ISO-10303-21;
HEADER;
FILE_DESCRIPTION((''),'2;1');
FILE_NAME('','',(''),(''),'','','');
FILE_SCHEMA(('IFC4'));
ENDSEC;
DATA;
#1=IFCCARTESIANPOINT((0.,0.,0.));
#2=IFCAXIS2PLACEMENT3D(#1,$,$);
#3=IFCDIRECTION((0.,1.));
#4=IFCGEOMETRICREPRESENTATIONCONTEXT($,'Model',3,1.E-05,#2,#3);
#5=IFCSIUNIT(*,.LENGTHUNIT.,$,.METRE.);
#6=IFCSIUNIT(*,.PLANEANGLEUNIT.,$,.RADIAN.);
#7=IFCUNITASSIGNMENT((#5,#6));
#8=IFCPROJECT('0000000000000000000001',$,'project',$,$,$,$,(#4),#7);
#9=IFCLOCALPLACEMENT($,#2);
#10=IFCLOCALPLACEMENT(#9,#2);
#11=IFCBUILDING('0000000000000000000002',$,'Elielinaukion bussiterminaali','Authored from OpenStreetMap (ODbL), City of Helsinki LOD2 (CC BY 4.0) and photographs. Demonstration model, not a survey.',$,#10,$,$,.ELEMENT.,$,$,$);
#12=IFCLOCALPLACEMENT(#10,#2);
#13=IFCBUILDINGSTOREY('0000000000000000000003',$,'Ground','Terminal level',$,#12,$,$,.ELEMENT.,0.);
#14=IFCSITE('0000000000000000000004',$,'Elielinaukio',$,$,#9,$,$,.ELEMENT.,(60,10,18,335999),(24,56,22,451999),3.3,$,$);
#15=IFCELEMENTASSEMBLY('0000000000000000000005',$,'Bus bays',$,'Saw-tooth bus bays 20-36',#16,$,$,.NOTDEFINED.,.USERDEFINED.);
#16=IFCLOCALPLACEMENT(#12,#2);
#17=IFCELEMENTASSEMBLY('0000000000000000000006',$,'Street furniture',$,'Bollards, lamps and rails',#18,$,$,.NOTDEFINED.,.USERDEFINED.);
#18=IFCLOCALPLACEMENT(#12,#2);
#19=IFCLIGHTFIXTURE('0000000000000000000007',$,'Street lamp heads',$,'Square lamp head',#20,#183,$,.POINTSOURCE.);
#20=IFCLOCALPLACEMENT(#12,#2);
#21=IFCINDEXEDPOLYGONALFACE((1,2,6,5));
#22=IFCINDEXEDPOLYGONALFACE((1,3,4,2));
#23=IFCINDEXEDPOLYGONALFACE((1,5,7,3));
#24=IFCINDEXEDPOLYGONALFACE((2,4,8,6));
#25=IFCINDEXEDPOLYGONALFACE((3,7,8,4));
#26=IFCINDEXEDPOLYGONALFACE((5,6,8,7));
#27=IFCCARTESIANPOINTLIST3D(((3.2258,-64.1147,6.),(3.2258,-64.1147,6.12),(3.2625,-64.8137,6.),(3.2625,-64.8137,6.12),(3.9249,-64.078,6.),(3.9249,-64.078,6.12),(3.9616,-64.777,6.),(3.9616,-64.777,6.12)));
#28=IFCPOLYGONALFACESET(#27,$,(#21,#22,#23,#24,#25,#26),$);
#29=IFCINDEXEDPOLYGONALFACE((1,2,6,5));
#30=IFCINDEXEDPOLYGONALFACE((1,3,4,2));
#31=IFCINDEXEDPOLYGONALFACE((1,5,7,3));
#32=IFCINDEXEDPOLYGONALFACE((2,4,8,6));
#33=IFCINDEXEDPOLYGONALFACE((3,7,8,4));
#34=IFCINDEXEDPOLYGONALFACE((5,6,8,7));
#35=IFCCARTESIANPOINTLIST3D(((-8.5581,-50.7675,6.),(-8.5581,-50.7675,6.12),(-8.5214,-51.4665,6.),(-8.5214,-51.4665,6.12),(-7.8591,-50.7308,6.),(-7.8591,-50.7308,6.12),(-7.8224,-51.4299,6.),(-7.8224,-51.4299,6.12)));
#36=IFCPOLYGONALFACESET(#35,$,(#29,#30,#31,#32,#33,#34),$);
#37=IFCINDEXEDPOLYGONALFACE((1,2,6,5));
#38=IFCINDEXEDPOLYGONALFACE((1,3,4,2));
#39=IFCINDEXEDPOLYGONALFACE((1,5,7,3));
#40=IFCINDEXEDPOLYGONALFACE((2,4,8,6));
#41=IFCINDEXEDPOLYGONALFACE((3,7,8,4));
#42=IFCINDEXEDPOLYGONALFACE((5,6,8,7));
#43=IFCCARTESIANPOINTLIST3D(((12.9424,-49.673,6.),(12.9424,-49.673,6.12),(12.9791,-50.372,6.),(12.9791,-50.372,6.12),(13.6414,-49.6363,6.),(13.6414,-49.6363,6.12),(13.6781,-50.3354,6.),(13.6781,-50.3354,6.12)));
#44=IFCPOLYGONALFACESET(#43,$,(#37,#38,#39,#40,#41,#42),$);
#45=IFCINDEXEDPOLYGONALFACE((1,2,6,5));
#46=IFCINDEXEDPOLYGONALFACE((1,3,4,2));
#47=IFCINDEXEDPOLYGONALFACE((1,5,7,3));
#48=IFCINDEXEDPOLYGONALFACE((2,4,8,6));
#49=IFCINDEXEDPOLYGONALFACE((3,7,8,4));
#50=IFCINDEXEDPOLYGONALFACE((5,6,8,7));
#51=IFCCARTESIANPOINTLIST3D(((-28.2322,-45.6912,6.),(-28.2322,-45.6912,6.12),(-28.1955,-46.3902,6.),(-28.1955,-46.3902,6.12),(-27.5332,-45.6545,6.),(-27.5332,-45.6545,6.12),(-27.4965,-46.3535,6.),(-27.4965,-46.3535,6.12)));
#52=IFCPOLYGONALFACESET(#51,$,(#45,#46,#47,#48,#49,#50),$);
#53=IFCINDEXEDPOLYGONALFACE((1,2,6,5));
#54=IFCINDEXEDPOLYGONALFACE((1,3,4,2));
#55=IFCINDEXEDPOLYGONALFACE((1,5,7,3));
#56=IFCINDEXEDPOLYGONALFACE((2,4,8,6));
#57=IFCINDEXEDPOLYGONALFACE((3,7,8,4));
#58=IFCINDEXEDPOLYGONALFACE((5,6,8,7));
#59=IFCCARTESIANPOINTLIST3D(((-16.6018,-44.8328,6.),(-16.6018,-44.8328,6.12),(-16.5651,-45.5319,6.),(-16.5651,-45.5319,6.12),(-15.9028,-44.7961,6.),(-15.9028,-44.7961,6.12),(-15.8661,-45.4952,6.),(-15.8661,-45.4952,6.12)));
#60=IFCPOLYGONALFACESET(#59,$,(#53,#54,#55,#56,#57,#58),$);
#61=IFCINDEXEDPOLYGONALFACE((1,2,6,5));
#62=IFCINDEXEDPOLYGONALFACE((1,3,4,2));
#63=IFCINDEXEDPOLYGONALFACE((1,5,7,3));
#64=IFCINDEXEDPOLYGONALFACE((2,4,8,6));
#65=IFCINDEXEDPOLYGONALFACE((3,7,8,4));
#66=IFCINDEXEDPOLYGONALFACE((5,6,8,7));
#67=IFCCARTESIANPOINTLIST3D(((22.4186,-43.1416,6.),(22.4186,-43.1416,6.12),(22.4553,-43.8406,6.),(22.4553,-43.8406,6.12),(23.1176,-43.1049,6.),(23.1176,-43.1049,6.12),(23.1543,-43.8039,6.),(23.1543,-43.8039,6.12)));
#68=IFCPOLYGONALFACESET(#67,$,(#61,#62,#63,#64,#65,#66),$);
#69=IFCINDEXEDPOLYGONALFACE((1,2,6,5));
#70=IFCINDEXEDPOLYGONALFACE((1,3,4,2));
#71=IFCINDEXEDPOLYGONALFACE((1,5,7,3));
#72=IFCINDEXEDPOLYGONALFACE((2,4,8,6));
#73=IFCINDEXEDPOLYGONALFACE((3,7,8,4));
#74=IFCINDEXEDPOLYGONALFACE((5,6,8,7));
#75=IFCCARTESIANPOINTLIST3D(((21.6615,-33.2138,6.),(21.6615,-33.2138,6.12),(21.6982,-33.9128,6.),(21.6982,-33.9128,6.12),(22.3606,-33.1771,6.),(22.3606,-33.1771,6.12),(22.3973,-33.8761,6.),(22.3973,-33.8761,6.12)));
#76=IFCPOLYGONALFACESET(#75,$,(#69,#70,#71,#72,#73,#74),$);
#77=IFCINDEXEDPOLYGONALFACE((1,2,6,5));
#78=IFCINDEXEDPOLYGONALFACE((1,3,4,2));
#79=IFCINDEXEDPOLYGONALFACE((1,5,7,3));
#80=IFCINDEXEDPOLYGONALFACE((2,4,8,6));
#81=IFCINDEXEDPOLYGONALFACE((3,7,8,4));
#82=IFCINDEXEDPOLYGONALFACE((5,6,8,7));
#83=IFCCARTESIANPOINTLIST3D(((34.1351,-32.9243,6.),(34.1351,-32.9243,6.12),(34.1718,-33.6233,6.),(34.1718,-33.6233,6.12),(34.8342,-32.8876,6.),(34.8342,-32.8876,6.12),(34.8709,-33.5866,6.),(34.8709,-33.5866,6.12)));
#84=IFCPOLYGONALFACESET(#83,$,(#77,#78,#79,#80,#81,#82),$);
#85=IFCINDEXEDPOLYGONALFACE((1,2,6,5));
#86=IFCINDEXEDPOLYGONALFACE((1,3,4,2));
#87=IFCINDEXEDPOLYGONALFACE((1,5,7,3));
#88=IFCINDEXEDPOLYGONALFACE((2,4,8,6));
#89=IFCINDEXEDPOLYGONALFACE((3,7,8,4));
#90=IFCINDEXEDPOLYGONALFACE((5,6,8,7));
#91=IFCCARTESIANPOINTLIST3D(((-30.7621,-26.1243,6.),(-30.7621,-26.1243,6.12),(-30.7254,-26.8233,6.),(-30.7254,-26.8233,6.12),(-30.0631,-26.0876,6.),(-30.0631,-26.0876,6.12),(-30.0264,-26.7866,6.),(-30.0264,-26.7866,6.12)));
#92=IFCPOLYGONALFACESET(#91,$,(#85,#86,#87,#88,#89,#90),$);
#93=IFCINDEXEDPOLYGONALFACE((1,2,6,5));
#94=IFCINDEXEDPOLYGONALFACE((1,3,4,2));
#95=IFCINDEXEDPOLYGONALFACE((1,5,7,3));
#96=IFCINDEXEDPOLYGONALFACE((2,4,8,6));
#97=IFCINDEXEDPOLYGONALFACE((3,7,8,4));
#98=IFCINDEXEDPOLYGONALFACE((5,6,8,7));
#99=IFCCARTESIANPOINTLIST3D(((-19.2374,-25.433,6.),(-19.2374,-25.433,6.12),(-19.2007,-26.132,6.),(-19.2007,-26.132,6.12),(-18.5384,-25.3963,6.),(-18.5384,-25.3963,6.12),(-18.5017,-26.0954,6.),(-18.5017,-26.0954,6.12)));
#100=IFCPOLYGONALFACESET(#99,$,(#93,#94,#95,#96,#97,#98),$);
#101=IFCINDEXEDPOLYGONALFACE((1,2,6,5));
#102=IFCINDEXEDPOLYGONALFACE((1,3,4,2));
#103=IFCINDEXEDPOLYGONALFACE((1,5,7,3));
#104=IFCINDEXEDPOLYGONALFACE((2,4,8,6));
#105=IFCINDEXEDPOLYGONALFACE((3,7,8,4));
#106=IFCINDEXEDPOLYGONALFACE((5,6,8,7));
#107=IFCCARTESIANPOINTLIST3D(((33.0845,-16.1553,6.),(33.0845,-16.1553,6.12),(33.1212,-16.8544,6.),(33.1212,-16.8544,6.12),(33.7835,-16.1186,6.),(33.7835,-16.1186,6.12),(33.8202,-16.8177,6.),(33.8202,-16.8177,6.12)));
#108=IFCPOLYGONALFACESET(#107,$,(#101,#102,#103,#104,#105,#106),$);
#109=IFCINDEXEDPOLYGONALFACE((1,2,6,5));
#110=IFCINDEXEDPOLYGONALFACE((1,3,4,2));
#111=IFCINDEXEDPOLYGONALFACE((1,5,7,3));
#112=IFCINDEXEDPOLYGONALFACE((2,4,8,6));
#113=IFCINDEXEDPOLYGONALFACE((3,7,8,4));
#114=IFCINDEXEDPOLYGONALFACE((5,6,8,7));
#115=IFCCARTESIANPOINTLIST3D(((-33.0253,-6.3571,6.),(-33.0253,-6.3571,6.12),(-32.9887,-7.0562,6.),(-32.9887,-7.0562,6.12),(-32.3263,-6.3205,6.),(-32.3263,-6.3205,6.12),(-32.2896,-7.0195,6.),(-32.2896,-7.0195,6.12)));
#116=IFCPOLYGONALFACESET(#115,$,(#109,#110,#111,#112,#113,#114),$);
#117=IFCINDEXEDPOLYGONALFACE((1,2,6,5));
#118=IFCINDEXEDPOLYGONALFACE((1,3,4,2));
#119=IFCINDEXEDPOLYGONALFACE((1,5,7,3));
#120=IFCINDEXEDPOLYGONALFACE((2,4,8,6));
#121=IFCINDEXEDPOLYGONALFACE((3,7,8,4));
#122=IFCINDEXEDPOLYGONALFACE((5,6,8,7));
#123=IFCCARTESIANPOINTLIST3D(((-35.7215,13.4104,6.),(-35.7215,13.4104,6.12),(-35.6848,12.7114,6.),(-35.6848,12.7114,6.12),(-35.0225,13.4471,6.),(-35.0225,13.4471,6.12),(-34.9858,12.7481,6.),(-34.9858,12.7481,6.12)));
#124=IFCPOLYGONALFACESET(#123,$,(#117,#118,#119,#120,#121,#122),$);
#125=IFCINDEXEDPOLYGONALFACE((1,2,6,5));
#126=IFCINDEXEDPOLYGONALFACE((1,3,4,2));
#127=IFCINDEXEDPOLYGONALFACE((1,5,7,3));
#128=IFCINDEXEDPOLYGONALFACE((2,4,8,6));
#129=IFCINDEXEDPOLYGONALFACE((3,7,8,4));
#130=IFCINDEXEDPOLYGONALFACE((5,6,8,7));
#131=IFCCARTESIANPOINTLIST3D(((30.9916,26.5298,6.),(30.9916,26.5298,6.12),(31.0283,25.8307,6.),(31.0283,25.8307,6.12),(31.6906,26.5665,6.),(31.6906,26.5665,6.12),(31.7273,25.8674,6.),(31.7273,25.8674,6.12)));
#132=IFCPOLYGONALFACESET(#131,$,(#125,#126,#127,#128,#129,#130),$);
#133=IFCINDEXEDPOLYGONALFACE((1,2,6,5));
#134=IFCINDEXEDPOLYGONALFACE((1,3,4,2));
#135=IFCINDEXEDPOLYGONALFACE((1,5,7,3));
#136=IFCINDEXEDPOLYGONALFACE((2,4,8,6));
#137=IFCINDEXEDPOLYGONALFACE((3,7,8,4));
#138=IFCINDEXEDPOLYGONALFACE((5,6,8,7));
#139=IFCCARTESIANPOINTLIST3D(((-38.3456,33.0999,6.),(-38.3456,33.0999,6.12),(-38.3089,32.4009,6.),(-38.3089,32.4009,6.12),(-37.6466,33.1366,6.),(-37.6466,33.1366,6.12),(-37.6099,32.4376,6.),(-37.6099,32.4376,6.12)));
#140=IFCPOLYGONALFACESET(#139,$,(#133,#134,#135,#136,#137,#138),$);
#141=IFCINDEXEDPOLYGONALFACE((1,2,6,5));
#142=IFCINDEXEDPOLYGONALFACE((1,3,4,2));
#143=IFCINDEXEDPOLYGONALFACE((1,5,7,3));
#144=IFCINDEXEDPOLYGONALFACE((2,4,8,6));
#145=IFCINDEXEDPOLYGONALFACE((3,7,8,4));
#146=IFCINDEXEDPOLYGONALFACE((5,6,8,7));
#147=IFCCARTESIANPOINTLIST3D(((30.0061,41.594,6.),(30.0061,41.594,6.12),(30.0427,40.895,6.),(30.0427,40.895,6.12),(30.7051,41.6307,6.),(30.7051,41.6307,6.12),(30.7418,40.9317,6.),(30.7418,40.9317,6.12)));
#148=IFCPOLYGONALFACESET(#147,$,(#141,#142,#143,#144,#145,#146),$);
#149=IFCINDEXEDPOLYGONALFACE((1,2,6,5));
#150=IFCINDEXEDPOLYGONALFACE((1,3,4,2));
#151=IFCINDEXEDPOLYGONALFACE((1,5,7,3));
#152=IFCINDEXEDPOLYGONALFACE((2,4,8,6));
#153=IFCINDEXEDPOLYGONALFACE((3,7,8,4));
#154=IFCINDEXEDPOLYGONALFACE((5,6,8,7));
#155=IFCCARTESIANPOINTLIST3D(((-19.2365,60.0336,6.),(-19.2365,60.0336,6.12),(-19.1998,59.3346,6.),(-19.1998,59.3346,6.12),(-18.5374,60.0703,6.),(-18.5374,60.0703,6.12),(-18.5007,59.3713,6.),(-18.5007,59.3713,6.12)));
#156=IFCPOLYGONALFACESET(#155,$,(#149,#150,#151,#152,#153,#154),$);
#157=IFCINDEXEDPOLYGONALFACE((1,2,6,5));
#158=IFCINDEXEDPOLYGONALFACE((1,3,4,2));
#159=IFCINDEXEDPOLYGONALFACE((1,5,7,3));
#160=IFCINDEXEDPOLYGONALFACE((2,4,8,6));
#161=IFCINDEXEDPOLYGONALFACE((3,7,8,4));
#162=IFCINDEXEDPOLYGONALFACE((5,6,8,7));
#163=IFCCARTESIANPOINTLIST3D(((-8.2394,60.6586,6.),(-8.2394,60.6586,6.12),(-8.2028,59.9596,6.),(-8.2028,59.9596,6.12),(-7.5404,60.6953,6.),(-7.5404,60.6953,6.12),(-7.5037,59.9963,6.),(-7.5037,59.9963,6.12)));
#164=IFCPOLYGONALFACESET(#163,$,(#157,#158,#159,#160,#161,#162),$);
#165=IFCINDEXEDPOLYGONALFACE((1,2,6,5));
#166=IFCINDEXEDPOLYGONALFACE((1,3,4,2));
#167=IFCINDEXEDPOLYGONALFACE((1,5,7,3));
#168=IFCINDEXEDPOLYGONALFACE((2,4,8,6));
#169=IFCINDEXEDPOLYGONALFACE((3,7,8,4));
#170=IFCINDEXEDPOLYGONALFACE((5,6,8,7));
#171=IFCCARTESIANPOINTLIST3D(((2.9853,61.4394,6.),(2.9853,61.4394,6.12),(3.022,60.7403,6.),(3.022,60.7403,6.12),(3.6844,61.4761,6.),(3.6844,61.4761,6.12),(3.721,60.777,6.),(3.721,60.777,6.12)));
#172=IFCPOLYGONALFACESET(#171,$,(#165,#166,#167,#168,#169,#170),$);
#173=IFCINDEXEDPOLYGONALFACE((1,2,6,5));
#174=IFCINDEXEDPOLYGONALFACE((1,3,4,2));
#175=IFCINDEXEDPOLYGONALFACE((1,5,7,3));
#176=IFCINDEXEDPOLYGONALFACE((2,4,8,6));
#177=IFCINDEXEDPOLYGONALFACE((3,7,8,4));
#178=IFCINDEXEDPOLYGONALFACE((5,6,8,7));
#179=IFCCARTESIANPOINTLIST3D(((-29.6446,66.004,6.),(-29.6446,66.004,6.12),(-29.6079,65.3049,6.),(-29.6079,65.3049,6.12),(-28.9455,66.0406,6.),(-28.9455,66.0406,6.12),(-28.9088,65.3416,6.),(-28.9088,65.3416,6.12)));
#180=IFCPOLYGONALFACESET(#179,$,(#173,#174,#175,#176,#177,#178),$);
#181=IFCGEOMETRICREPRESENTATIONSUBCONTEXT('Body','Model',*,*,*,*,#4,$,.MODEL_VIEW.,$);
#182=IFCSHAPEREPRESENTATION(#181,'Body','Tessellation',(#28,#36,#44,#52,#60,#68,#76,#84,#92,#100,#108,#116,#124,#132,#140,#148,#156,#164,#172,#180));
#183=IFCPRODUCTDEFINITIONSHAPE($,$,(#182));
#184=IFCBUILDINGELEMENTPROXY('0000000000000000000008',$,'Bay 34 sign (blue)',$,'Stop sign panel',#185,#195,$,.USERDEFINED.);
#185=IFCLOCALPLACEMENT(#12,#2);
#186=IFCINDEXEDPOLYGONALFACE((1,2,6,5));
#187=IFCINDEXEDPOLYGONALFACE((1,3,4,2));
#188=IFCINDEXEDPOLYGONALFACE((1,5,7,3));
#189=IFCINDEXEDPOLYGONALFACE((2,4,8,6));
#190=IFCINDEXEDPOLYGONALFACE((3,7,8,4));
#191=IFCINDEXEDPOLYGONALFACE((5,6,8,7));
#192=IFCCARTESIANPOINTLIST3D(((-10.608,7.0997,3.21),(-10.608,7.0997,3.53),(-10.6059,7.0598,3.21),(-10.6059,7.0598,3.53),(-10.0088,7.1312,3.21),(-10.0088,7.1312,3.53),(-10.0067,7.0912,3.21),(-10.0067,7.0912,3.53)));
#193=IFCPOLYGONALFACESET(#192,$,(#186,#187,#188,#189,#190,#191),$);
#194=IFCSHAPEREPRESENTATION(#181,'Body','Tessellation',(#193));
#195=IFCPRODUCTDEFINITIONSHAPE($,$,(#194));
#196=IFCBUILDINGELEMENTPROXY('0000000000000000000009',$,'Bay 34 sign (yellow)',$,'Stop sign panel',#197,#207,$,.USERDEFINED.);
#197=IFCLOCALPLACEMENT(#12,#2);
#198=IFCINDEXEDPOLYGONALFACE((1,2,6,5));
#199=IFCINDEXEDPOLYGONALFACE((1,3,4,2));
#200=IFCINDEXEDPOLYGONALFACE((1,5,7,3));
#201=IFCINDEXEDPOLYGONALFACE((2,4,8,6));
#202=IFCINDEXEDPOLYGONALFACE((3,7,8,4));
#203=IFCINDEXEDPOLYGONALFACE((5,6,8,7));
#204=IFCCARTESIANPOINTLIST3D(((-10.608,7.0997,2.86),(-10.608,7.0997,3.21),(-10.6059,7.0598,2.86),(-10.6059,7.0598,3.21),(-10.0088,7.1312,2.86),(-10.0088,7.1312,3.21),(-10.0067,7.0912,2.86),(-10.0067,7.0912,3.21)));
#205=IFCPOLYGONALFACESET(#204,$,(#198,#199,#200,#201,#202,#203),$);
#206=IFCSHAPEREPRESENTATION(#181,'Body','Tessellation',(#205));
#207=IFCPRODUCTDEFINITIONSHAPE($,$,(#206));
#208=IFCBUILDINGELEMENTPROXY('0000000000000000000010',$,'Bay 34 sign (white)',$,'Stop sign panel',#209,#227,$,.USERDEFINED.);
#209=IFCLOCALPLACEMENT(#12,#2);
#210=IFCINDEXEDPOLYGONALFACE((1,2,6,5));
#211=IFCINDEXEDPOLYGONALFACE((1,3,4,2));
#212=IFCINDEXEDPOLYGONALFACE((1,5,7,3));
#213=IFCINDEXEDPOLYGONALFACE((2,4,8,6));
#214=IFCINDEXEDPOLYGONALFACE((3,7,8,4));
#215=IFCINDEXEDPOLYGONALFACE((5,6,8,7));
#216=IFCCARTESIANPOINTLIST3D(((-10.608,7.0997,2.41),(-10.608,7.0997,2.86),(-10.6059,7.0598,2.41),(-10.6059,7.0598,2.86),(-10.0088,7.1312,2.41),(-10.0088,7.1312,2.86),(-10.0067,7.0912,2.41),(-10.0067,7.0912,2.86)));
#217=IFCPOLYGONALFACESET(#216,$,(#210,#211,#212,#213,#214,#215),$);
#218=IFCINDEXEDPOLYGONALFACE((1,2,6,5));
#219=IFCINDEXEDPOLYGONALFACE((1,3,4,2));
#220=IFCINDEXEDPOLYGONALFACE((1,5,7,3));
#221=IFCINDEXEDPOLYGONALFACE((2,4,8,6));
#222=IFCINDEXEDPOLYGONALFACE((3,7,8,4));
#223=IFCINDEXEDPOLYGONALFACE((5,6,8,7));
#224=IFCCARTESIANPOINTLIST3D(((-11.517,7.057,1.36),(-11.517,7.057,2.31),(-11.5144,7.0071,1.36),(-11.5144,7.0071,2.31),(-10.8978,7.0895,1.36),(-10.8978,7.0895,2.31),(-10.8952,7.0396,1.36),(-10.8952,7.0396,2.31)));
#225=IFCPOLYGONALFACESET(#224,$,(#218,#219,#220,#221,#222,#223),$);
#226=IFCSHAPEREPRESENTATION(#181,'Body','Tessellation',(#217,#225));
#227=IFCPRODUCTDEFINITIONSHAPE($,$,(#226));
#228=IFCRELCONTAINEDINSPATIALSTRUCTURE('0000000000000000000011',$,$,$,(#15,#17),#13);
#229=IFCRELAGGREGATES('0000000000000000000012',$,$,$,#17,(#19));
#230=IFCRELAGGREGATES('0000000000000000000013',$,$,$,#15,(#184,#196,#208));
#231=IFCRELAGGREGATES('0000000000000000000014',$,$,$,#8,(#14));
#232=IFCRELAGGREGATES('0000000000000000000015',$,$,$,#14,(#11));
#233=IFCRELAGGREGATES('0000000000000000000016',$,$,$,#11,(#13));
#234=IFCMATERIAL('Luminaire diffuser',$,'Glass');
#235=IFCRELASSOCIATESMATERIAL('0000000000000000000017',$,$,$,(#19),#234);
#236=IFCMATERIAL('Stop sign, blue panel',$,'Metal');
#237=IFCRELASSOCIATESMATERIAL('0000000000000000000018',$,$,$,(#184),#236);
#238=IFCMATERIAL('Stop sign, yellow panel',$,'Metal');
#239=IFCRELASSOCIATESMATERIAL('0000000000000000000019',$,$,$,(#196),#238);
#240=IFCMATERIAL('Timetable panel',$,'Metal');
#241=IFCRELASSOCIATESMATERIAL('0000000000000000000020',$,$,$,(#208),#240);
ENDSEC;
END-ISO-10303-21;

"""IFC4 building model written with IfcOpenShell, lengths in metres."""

from ifc_helpers import new_model, si_unit, direction, frame, frame_2d, origin, place, context, subcontext, project, spatial, rectangle, extrude, material, element, aggregate, save


model = new_model("IFC4")

# Units and contexts
model_context = context("Model", 3, precision=1e-05, world=origin(), true_north=direction((0.0, 1.0)))
body_context = subcontext(model_context, "Body", "Model", "MODEL_VIEW")
ifc_project = project(units=[si_unit("LENGTHUNIT", "METRE"), si_unit("PLANEANGLEUNIT", "RADIAN")], contexts=[model_context])

# Site, building, storey
site_placement = place(None, origin())
site = spatial("IfcSite", under=ifc_project, at=site_placement, Name="Elielinaukio", CompositionType="ELEMENT", RefLatitude=(60, 10, 18, 335999), RefLongitude=(24, 56, 22, 451999), RefElevation=3.3)
building_placement = place(site_placement, origin())
building = spatial("IfcBuilding", under=site, at=building_placement, Name="Elielinaukion bussiterminaali", Description="Authored from OpenStreetMap (ODbL), City of Helsinki LOD2 (CC BY 4.0) and photographs. Demonstration model, not a survey.", CompositionType="ELEMENT")
storey_placement = place(building_placement, origin())
storey = spatial("IfcBuildingStorey", under=building, at=storey_placement, Name="Ground", Description="Terminal level", CompositionType="ELEMENT", Elevation=0.0)

# Element assembly
assembly_1_placement = place(building_placement, origin())
assembly_1 = element("IfcElementAssembly", 1, at=assembly_1_placement, inside=storey, Name="Bus bays", ObjectType="Saw-tooth bus bays 20-36", AssemblyPlace="NOTDEFINED", PredefinedType="USERDEFINED")

# Element assembly
assembly_2_placement = place(building_placement, origin())
assembly_2 = element("IfcElementAssembly", 2, at=assembly_2_placement, inside=storey, Name="Street furniture", ObjectType="Bollards, lamps and rails", AssemblyPlace="NOTDEFINED", PredefinedType="USERDEFINED")

# Light fixture
ifc_material_1 = material(Name="Luminaire diffuser", Category="Glass")
light_fixture_1_placement = place(building_placement, origin())
light_fixture_1 = element("IfcLightFixture", 3, at=light_fixture_1_placement, material=ifc_material_1, Name="Street lamp heads", ObjectType="Square lamp head", PredefinedType="POINTSOURCE", context=body_context, shape_type="SweptSolid", body=[
    extrude(rectangle(XDim=0.7, YDim=0.7, at=frame_2d((0.0, 0.0), x_axis=(-0.052408, 0.998626))), frame((3.5937, -64.4459, 6.0)), (0.0, 0.0, 1.0), 0.12),
    extrude(rectangle(XDim=0.7, YDim=0.7, at=frame_2d((0.0, 0.0), x_axis=(-0.052408, 0.998626))), frame((-8.1903, -51.0987, 6.0)), (0.0, 0.0, 1.0), 0.12),
    extrude(rectangle(XDim=0.7, YDim=0.7, at=frame_2d((0.0, 0.0), x_axis=(-0.052408, 0.998626))), frame((13.3103, -50.0042, 6.0)), (0.0, 0.0, 1.0), 0.12),
    extrude(rectangle(XDim=0.7, YDim=0.7, at=frame_2d((0.0, 0.0), x_axis=(-0.052408, 0.998626))), frame((-27.8643, -46.0223, 6.0)), (0.0, 0.0, 1.0), 0.12),
    extrude(rectangle(XDim=0.7, YDim=0.7, at=frame_2d((0.0, 0.0), x_axis=(-0.052408, 0.998626))), frame((-16.2339, -45.164, 6.0)), (0.0, 0.0, 1.0), 0.12),
    extrude(rectangle(XDim=0.7, YDim=0.7, at=frame_2d((0.0, 0.0), x_axis=(-0.052408, 0.998626))), frame((22.7864, -43.4727, 6.0)), (0.0, 0.0, 1.0), 0.12),
    extrude(rectangle(XDim=0.7, YDim=0.7, at=frame_2d((0.0, 0.0), x_axis=(-0.052408, 0.998626))), frame((22.0294, -33.5449, 6.0)), (0.0, 0.0, 1.0), 0.12),
    extrude(rectangle(XDim=0.7, YDim=0.7, at=frame_2d((0.0, 0.0), x_axis=(-0.052408, 0.998626))), frame((34.503, -33.2554, 6.0)), (0.0, 0.0, 1.0), 0.12),
    extrude(rectangle(XDim=0.7, YDim=0.7, at=frame_2d((0.0, 0.0), x_axis=(-0.052408, 0.998626))), frame((-30.3942, -26.4555, 6.0)), (0.0, 0.0, 1.0), 0.12),
    extrude(rectangle(XDim=0.7, YDim=0.7, at=frame_2d((0.0, 0.0), x_axis=(-0.052408, 0.998626))), frame((-18.8695, -25.7642, 6.0)), (0.0, 0.0, 1.0), 0.12),
    extrude(rectangle(XDim=0.7, YDim=0.7, at=frame_2d((0.0, 0.0), x_axis=(-0.052408, 0.998626))), frame((33.4524, -16.4865, 6.0)), (0.0, 0.0, 1.0), 0.12),
    extrude(rectangle(XDim=0.7, YDim=0.7, at=frame_2d((0.0, 0.0), x_axis=(-0.052408, 0.998626))), frame((-32.6575, -6.6883, 6.0)), (0.0, 0.0, 1.0), 0.12),
    extrude(rectangle(XDim=0.7, YDim=0.7, at=frame_2d((0.0, 0.0), x_axis=(-0.052408, 0.998626))), frame((-35.3537, 13.0792, 6.0)), (0.0, 0.0, 1.0), 0.12),
    extrude(rectangle(XDim=0.7, YDim=0.7, at=frame_2d((0.0, 0.0), x_axis=(-0.052408, 0.998626))), frame((31.3594, 26.1986, 6.0)), (0.0, 0.0, 1.0), 0.12),
    extrude(rectangle(XDim=0.7, YDim=0.7, at=frame_2d((0.0, 0.0), x_axis=(-0.052408, 0.998626))), frame((-37.9777, 32.7688, 6.0)), (0.0, 0.0, 1.0), 0.12),
    extrude(rectangle(XDim=0.7, YDim=0.7, at=frame_2d((0.0, 0.0), x_axis=(-0.052408, 0.998626))), frame((30.3739, 41.2628, 6.0)), (0.0, 0.0, 1.0), 0.12),
    extrude(rectangle(XDim=0.7, YDim=0.7, at=frame_2d((0.0, 0.0), x_axis=(-0.052408, 0.998626))), frame((-18.8686, 59.7025, 6.0)), (0.0, 0.0, 1.0), 0.12),
    extrude(rectangle(XDim=0.7, YDim=0.7, at=frame_2d((0.0, 0.0), x_axis=(-0.052408, 0.998626))), frame((-7.8716, 60.3274, 6.0)), (0.0, 0.0, 1.0), 0.12),
    extrude(rectangle(XDim=0.7, YDim=0.7, at=frame_2d((0.0, 0.0), x_axis=(-0.052408, 0.998626))), frame((3.3532, 61.1082, 6.0)), (0.0, 0.0, 1.0), 0.12),
    extrude(rectangle(XDim=0.7, YDim=0.7, at=frame_2d((0.0, 0.0), x_axis=(-0.052408, 0.998626))), frame((-29.2767, 65.6728, 6.0)), (0.0, 0.0, 1.0), 0.12),
])
aggregate(assembly_2, [light_fixture_1])

# Building element proxies
ifc_material_2 = material(Name="Stop sign, blue panel", Category="Metal")
proxy_1_placement = place(building_placement, origin())
proxy_1 = element("IfcBuildingElementProxy", 4, at=proxy_1_placement, material=ifc_material_2, Name="Bay 34 sign (blue)", ObjectType="Stop sign panel", PredefinedType="USERDEFINED", context=body_context, shape_type="SweptSolid", body=[
    extrude(rectangle(XDim=0.04, YDim=0.6, at=frame_2d((0.0, 0.0), x_axis=(-0.052408, 0.998626))), frame((-10.3073, 7.0955, 3.21)), (0.0, 0.0, 1.0), 0.32),
])
ifc_material_3 = material(Name="Stop sign, yellow panel", Category="Metal")
proxy_2_placement = place(building_placement, origin())
proxy_2 = element("IfcBuildingElementProxy", 5, at=proxy_2_placement, material=ifc_material_3, Name="Bay 34 sign (yellow)", ObjectType="Stop sign panel", PredefinedType="USERDEFINED", context=body_context, shape_type="SweptSolid", body=[
    extrude(rectangle(XDim=0.04, YDim=0.6, at=frame_2d((0.0, 0.0), x_axis=(-0.052408, 0.998626))), frame((-10.3073, 7.0955, 2.86)), (0.0, 0.0, 1.0), 0.35),
])
ifc_material_4 = material(Name="Timetable panel", Category="Metal")
proxy_3_placement = place(building_placement, origin())
proxy_3 = element("IfcBuildingElementProxy", 6, at=proxy_3_placement, material=ifc_material_4, Name="Bay 34 sign (white)", ObjectType="Stop sign panel", PredefinedType="USERDEFINED", context=body_context, shape_type="SweptSolid", body=[
    extrude(rectangle(XDim=0.04, YDim=0.6, at=frame_2d((0.0, 0.0), x_axis=(-0.052408, 0.998626))), frame((-10.3073, 7.0955, 2.41)), (0.0, 0.0, 1.0), 0.45),
    extrude(rectangle(XDim=0.05, YDim=0.62, at=frame_2d((0.0, 0.0), x_axis=(-0.052408, 0.998626))), frame((-11.2061, 7.0483, 1.36)), (0.0, 0.0, 1.0), 0.95),
])
aggregate(assembly_1, [proxy_1, proxy_2, proxy_3])

save(model, "model.ifc")
